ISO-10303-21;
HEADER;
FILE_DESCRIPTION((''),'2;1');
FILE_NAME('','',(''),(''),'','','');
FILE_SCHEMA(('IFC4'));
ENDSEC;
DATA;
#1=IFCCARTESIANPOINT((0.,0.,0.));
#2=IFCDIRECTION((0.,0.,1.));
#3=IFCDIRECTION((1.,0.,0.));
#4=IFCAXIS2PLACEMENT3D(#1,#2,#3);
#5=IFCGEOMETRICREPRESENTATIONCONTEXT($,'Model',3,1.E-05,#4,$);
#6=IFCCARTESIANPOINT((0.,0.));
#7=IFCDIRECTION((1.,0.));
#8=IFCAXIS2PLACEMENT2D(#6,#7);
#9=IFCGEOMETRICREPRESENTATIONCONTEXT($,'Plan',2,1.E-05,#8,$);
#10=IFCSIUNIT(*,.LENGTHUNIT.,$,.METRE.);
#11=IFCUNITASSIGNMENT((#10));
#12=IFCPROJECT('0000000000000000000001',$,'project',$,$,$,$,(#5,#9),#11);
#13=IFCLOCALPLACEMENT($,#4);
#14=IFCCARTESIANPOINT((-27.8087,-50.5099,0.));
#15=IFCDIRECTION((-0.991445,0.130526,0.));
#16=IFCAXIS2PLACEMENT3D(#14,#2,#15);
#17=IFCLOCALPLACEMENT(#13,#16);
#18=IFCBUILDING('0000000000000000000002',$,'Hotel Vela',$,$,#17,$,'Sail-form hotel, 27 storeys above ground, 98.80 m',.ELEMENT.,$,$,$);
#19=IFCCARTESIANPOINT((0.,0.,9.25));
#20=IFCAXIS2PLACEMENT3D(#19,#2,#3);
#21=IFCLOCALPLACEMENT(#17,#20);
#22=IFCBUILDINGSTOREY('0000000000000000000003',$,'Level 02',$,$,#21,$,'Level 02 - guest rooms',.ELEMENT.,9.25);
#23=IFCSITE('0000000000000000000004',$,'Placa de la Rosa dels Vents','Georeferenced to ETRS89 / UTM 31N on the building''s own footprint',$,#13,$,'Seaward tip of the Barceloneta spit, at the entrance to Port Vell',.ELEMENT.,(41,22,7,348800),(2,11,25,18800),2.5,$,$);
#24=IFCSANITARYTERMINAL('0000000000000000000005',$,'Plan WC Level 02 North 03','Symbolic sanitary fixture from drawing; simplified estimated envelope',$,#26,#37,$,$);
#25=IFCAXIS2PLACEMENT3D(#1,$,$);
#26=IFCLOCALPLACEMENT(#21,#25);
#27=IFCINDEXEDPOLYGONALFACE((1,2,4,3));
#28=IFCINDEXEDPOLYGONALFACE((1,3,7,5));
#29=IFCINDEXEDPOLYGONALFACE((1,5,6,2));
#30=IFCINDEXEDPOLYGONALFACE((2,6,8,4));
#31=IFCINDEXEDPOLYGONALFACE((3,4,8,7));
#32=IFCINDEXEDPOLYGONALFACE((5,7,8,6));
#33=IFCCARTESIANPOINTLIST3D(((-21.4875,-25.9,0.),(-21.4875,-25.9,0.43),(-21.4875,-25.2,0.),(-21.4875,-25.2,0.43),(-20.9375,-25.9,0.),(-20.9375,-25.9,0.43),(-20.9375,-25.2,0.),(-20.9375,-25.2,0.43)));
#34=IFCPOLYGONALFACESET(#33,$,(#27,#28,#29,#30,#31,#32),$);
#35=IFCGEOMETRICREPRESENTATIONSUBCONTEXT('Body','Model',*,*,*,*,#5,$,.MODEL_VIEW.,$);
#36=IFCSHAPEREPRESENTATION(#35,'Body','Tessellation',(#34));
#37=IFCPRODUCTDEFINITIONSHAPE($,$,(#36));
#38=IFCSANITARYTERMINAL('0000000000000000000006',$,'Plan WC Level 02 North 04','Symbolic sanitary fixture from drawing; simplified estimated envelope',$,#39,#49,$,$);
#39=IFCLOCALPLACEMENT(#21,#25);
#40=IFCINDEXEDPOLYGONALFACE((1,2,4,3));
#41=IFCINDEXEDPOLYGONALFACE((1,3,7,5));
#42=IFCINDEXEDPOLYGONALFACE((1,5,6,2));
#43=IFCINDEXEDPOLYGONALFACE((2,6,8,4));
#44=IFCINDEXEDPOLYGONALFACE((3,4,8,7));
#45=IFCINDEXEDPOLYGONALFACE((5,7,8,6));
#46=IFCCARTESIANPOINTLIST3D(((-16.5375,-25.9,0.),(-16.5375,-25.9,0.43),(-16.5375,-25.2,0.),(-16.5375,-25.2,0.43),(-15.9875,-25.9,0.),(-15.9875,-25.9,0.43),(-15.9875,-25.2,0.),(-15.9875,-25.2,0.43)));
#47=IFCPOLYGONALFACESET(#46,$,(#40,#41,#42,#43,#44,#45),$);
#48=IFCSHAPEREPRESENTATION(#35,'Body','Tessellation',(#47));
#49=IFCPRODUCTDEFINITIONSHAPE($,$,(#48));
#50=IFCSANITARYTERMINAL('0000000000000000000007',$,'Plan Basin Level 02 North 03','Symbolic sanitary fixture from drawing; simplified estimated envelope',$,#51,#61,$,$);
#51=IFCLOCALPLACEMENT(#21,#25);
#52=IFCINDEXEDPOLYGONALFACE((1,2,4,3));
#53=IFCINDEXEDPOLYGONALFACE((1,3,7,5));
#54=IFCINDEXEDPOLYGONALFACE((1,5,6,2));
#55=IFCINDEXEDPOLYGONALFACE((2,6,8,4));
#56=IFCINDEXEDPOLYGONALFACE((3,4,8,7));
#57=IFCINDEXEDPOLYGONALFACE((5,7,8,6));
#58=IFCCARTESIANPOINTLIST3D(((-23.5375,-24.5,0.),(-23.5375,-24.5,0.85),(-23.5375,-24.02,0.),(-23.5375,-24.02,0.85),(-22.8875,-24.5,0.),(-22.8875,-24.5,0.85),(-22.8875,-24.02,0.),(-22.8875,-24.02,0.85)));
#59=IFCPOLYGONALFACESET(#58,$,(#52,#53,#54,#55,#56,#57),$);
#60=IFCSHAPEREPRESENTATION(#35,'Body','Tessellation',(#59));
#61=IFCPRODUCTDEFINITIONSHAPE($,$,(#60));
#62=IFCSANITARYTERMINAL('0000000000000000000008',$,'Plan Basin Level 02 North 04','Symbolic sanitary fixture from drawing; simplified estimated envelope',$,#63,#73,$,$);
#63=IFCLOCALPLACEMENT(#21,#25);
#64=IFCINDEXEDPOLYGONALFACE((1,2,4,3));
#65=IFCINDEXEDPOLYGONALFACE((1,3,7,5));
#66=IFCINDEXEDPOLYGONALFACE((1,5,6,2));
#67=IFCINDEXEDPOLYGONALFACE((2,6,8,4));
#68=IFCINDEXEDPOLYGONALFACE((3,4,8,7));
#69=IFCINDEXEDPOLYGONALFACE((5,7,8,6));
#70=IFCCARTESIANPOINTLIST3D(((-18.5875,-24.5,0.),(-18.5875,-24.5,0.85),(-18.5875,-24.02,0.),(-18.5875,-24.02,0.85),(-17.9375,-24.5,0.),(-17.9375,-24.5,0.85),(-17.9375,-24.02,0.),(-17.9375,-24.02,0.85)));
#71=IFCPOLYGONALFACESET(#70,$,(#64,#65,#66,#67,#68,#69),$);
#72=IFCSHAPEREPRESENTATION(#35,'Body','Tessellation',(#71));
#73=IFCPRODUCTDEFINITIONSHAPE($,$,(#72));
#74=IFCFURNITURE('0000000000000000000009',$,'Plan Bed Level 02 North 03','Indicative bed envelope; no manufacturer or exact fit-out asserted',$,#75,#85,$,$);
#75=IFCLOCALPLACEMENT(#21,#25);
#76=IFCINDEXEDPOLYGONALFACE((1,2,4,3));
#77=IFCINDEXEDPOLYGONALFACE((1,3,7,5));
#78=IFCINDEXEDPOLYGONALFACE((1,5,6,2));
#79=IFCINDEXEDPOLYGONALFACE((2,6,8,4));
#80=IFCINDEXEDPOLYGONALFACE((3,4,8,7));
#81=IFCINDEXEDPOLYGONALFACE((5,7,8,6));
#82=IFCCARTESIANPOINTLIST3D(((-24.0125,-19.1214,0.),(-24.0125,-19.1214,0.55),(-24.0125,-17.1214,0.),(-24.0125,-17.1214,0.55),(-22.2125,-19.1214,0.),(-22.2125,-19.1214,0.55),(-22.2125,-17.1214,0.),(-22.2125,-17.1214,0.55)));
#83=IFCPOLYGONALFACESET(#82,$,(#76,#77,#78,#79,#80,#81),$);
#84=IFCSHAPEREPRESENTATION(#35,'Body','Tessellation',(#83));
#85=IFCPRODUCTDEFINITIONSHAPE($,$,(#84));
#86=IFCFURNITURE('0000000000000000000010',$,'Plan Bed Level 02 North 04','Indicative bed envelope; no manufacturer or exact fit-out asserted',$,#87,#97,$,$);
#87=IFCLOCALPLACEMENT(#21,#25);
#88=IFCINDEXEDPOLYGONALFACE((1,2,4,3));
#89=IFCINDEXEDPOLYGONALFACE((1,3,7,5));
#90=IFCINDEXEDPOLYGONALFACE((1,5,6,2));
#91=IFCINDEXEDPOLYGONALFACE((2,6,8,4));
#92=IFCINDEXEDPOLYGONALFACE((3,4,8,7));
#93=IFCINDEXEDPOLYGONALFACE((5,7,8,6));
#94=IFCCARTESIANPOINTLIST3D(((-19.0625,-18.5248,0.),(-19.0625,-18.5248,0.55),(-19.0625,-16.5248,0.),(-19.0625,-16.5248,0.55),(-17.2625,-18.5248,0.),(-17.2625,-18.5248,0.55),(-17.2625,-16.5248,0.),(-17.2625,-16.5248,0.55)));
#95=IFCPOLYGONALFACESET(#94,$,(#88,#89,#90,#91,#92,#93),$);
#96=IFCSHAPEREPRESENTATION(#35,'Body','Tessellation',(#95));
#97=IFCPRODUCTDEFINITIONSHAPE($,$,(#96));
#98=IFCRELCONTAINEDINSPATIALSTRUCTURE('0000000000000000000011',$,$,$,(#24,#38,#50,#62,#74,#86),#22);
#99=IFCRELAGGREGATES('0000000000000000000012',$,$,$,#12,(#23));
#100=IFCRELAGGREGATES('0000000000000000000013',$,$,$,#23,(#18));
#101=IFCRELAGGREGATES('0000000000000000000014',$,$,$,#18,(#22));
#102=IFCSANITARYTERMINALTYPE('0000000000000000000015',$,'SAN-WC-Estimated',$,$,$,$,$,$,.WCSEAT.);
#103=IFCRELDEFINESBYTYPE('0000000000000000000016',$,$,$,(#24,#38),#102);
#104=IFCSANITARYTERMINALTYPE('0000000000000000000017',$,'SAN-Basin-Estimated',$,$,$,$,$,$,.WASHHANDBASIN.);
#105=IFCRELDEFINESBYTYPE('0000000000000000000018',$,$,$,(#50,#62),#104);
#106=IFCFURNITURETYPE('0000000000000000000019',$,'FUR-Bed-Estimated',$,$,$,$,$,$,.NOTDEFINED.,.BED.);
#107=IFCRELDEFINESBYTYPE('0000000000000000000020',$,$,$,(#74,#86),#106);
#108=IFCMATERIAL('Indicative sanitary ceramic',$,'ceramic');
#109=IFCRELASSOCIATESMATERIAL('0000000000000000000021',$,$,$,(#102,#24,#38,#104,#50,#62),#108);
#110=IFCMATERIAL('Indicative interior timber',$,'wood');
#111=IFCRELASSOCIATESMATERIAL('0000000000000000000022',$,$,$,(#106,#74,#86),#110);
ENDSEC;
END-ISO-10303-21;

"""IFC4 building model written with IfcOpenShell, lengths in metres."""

from ifc_helpers import new_model, si_unit, frame, origin_with_axes, origin_2d_with_axis, place, context, subcontext, project, spatial, line, indexed_curve, outline, extrude, material, type_object, element, save


model = new_model("IFC4")

# Units and contexts
model_context = context("Model", 3, precision=1e-05, world=origin_with_axes())
plan_context = context("Plan", 2, precision=1e-05, world=origin_2d_with_axis())
body_context = subcontext(model_context, "Body", "Model", "MODEL_VIEW")
ifc_project = project(units=[si_unit("LENGTHUNIT", "METRE")], contexts=[model_context, plan_context])

# Site, building, storey
site_placement = place(None, origin_with_axes())
site = spatial("IfcSite", under=ifc_project, at=site_placement, Name="Placa de la Rosa dels Vents", Description="Georeferenced to ETRS89 / UTM 31N on the building's own footprint", LongName="Seaward tip of the Barceloneta spit, at the entrance to Port Vell", CompositionType="ELEMENT", RefLatitude=(41, 22, 7, 348800), RefLongitude=(2, 11, 25, 18800), RefElevation=2.5)
building_placement = place(site_placement, frame((-27.8087, -50.5099, 0.0), z_axis=(0.0, 0.0, 1.0), x_axis=(-0.991445, 0.130526, 0.0)))
building = spatial("IfcBuilding", under=site, at=building_placement, Name="Hotel Vela", LongName="Sail-form hotel, 27 storeys above ground, 98.80 m", CompositionType="ELEMENT")
storey_placement = place(building_placement, frame((0.0, 0.0, 9.25), z_axis=(0.0, 0.0, 1.0), x_axis=(1.0, 0.0, 0.0)))
storey = spatial("IfcBuildingStorey", under=building, at=storey_placement, Name="Level 02", LongName="Level 02 - guest rooms", CompositionType="ELEMENT", Elevation=9.25)

# Shared definitions
ifc_material_1 = material(Name="Indicative interior timber", Category="wood")

# Sanitary terminals
ifc_material_2 = material(Name="Indicative sanitary ceramic", Category="ceramic")
sanitary_terminal_type_1 = type_object("IfcSanitaryTerminalType", Name="SAN-WC-Estimated", PredefinedType="WCSEAT", material=ifc_material_2)
for number, where, z_axis, x_axis, name in (
    (1, (-21.4875, -25.9, 0.0), (0.0, 0.0, 1.0), (1.0, 0.0, 0.0), "Plan WC Level 02 North 03"),
    (2, (-16.5375, -25.9, 0.0), (0.0, 0.0, 1.0), (1.0, 0.0, 0.0), "Plan WC Level 02 North 04"),
):
    element("IfcSanitaryTerminal", number, at=place(storey_placement, frame(where, z_axis=z_axis, x_axis=x_axis)), inside=storey, type_object=sanitary_terminal_type_1, material=ifc_material_2, Name=name, Description="Symbolic sanitary fixture from drawing; simplified estimated envelope", context=body_context, shape_type="SweptSolid", body=[
        extrude(outline(indexed_curve([(0.0, 0.0), (0.55, 0.0), (0.55, 0.7), (0.0, 0.7)], segments=[line(1, 2, 3, 4, 1)])), origin_with_axes(), (0.0, 0.0, 1.0), 0.43),
    ])
sanitary_terminal_type_2 = type_object("IfcSanitaryTerminalType", Name="SAN-Basin-Estimated", PredefinedType="WASHHANDBASIN", material=ifc_material_2)
for number, where, z_axis, x_axis, name in (
    (3, (-23.5375, -24.5, 0.0), (0.0, 0.0, 1.0), (1.0, 0.0, 0.0), "Plan Basin Level 02 North 03"),
    (4, (-18.5875, -24.5, 0.0), (0.0, 0.0, 1.0), (1.0, 0.0, 0.0), "Plan Basin Level 02 North 04"),
):
    element("IfcSanitaryTerminal", number, at=place(storey_placement, frame(where, z_axis=z_axis, x_axis=x_axis)), inside=storey, type_object=sanitary_terminal_type_2, material=ifc_material_2, Name=name, Description="Symbolic sanitary fixture from drawing; simplified estimated envelope", context=body_context, shape_type="SweptSolid", body=[
        extrude(outline(indexed_curve([(0.0, 0.0), (0.65, 0.0), (0.65, 0.48), (0.0, 0.48)], segments=[line(1, 2, 3, 4, 1)])), origin_with_axes(), (0.0, 0.0, 1.0), 0.85),
    ])

# Furniture
furniture_type = type_object("IfcFurnitureType", Name="FUR-Bed-Estimated", AssemblyPlace="NOTDEFINED", PredefinedType="BED", material=ifc_material_1)
for number, where, z_axis, x_axis, name in (
    (5, (-24.0125, -19.1214, 0.0), (0.0, 0.0, 1.0), (1.0, 0.0, 0.0), "Plan Bed Level 02 North 03"),
    (6, (-19.0625, -18.5248, 0.0), (0.0, 0.0, 1.0), (1.0, 0.0, 0.0), "Plan Bed Level 02 North 04"),
):
    element("IfcFurniture", number, at=place(storey_placement, frame(where, z_axis=z_axis, x_axis=x_axis)), inside=storey, type_object=furniture_type, material=ifc_material_1, Name=name, Description="Indicative bed envelope; no manufacturer or exact fit-out asserted", context=body_context, shape_type="SweptSolid", body=[
        extrude(outline(indexed_curve([(0.0, 0.0), (1.8, 0.0), (1.8, 2.0), (0.0, 2.0)], segments=[line(1, 2, 3, 4, 1)])), origin_with_axes(), (0.0, 0.0, 1.0), 0.55),
    ])

save(model, "model.ifc")
